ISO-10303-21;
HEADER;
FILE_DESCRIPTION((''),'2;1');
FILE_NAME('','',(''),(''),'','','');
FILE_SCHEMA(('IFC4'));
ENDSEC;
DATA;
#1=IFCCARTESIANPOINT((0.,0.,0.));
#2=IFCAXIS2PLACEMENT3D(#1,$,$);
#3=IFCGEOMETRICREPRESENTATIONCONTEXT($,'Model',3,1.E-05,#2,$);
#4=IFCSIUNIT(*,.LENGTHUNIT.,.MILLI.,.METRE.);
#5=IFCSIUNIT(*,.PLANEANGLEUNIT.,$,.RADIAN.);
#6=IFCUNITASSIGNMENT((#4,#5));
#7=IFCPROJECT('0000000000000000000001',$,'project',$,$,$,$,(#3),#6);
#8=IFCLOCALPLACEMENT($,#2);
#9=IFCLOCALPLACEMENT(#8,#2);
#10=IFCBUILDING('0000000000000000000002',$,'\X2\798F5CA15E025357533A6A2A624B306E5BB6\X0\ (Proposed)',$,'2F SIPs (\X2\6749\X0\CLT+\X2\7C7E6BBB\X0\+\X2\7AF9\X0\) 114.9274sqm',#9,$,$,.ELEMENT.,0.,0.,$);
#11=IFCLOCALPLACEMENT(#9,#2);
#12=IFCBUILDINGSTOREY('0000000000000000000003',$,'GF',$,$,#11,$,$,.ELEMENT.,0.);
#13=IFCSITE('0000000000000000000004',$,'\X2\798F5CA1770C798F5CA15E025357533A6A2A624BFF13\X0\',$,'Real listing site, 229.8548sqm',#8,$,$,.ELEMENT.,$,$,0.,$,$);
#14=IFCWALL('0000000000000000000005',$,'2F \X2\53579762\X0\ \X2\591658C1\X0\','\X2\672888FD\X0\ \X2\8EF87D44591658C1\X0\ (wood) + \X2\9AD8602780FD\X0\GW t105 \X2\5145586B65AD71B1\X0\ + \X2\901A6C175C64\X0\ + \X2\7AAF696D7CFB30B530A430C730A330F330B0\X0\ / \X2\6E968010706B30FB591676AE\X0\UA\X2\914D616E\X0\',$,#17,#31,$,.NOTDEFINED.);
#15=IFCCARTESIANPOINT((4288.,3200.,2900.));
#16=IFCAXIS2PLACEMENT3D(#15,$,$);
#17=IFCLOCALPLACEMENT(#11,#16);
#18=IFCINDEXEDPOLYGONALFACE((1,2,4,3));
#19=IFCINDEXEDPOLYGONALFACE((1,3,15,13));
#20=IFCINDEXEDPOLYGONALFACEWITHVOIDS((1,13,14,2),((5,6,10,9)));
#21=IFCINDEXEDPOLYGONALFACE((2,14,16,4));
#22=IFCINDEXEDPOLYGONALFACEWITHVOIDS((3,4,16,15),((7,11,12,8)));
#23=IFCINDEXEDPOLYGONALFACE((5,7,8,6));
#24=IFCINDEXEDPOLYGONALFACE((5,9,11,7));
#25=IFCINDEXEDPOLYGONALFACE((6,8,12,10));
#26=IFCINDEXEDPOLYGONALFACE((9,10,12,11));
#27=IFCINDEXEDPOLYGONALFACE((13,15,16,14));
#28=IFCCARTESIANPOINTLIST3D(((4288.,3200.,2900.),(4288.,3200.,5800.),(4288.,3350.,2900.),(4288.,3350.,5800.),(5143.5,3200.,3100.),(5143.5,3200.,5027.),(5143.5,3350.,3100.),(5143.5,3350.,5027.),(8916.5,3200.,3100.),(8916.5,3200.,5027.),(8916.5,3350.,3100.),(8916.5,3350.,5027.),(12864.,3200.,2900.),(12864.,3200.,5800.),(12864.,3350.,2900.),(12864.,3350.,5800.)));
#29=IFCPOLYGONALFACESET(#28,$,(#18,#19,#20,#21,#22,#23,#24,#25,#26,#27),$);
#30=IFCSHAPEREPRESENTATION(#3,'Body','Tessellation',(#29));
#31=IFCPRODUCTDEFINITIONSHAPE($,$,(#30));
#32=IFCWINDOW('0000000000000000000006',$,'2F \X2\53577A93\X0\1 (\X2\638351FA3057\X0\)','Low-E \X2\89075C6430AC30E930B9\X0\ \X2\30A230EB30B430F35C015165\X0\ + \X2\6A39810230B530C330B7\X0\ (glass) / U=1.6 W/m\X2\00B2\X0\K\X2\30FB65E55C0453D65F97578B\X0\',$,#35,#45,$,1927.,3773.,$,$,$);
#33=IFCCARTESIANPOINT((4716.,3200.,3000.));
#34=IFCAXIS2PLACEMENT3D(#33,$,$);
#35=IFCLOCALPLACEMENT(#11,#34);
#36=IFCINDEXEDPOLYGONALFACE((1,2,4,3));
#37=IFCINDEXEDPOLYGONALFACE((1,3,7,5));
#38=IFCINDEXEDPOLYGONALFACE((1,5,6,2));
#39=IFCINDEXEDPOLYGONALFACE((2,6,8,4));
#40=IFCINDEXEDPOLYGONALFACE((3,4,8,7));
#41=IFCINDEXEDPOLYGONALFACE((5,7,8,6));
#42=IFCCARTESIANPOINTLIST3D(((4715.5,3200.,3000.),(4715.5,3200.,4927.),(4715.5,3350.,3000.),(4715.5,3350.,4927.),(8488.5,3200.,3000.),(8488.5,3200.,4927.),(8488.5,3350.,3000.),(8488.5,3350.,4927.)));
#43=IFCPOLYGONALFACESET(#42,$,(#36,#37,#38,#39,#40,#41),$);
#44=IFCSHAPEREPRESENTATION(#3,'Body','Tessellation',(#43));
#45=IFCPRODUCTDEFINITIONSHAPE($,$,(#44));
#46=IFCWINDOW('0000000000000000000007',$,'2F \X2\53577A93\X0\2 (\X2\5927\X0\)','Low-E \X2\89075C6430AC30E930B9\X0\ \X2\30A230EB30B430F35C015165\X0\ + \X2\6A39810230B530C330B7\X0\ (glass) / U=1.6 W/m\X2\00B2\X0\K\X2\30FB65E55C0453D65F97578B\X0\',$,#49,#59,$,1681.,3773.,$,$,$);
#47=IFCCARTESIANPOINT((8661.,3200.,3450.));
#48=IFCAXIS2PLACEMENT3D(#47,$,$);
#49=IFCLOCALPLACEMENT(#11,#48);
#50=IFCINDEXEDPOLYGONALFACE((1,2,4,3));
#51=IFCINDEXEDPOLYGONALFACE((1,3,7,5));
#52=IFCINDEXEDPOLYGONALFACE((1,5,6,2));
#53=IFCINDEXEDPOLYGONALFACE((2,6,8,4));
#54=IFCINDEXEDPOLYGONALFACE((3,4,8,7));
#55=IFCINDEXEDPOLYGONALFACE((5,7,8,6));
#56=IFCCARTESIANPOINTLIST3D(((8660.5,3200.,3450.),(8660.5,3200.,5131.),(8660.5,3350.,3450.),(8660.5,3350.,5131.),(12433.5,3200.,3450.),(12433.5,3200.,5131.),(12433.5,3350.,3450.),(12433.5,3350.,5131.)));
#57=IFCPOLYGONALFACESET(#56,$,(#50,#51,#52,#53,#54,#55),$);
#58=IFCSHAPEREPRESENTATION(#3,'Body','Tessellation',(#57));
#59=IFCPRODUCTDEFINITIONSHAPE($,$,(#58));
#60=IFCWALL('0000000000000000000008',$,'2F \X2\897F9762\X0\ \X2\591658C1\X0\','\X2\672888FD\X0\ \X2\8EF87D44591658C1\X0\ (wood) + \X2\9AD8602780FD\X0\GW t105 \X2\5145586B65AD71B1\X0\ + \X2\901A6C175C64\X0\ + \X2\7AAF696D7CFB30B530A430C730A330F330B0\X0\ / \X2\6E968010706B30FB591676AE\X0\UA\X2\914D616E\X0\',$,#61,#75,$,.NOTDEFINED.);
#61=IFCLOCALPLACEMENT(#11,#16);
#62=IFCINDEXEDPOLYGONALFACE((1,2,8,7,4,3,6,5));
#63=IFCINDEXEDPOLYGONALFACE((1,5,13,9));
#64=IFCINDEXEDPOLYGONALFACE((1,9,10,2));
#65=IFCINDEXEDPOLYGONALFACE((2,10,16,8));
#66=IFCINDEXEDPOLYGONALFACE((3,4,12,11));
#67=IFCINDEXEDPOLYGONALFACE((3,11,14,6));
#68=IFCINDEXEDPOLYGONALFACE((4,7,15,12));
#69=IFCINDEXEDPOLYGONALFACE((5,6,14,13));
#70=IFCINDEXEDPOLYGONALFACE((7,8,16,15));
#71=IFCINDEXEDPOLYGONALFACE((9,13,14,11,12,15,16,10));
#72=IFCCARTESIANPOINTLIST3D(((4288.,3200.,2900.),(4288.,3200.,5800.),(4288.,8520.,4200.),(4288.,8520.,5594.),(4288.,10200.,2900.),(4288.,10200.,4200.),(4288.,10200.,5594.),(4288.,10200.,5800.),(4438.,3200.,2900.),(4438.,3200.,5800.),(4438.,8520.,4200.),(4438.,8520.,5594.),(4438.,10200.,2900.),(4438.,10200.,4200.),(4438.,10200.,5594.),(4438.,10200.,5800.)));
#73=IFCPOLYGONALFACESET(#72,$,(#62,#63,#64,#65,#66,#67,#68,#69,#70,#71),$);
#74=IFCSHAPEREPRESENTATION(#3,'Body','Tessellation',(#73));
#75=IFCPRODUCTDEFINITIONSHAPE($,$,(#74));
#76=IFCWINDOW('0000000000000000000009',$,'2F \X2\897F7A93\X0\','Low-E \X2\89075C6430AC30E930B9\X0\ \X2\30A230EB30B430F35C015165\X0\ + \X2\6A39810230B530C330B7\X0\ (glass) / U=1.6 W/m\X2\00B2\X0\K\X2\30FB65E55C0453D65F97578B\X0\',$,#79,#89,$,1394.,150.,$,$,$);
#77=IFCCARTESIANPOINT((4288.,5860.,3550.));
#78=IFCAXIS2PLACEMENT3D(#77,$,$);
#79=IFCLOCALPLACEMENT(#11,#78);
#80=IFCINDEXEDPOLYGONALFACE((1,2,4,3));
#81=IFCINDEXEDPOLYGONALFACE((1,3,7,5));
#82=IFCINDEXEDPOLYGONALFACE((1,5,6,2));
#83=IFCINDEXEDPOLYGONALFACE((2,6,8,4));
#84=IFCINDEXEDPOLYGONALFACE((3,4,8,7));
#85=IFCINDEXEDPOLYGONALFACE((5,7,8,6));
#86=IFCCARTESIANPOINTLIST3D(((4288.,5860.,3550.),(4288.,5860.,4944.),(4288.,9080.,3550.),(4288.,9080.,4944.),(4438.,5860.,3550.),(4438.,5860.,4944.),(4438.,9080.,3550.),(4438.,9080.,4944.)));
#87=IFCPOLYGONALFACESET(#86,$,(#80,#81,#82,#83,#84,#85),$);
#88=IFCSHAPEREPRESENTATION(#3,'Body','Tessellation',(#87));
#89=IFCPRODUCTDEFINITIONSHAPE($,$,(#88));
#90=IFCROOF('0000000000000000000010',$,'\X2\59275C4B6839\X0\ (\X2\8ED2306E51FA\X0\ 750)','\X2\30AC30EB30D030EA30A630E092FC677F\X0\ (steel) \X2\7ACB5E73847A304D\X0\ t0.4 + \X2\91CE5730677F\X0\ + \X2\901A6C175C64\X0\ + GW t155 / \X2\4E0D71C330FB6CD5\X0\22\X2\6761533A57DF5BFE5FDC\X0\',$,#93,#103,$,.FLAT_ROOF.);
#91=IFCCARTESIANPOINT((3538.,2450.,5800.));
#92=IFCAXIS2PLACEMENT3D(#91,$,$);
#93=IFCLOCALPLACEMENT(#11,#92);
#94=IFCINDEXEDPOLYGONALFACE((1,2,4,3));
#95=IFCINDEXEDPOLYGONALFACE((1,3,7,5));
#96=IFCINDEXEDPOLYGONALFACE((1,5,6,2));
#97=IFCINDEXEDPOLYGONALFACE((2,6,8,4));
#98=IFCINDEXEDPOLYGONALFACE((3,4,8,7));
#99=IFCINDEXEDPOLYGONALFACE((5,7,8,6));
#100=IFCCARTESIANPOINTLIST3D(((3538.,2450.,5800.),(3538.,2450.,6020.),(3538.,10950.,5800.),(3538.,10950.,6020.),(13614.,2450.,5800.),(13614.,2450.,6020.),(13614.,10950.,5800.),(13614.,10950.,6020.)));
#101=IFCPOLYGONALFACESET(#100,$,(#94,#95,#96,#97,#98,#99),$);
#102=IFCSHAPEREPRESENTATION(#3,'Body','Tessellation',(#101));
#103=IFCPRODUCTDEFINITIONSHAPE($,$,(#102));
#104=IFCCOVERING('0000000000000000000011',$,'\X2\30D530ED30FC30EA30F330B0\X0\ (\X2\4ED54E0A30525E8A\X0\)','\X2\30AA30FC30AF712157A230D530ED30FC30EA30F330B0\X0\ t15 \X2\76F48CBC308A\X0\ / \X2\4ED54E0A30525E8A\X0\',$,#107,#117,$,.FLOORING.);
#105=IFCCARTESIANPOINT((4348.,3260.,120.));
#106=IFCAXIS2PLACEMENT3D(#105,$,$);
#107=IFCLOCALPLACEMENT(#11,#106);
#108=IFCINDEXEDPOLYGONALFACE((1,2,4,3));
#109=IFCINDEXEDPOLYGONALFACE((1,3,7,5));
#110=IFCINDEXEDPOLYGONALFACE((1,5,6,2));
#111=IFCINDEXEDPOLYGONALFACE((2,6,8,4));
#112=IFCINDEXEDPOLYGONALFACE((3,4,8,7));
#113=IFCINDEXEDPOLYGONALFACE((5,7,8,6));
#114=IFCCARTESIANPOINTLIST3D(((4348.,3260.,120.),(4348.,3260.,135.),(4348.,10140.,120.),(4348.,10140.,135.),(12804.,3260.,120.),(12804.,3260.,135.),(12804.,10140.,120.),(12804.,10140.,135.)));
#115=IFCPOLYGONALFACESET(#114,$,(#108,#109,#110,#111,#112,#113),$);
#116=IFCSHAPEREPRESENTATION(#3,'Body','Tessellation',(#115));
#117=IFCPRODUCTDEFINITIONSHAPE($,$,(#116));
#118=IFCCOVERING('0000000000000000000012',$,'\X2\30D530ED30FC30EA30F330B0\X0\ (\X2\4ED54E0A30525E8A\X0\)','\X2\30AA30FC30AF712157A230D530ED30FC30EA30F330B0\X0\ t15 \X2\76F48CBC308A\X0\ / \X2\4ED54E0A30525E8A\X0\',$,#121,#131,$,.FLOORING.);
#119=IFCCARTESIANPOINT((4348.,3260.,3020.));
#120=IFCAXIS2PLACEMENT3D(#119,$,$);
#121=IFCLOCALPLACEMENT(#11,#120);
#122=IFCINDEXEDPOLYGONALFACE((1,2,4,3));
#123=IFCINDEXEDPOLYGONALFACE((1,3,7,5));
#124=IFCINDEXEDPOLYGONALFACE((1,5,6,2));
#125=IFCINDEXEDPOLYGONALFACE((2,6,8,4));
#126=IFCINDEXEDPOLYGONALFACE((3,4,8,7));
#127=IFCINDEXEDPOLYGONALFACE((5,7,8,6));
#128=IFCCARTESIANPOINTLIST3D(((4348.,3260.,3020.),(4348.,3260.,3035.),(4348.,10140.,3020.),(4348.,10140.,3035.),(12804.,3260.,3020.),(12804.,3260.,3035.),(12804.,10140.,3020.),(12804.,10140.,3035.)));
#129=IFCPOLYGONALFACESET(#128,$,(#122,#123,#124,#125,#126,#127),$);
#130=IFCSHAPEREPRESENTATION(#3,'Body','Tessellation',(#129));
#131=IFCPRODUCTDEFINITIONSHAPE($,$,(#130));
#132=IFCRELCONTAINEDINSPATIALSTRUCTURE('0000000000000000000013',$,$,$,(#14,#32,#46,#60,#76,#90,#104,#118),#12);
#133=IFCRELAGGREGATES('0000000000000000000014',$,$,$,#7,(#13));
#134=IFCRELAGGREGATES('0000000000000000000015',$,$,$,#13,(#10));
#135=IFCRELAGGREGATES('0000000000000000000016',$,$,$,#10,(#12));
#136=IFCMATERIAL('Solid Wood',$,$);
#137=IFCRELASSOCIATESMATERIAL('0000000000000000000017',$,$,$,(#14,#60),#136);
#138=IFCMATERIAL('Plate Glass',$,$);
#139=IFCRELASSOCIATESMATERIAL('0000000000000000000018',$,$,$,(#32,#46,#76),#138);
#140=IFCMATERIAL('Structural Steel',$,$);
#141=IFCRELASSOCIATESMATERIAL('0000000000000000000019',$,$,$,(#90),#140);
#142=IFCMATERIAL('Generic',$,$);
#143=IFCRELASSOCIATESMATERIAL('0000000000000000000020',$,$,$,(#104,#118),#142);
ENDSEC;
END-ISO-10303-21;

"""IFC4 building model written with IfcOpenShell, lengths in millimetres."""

from ifc_helpers import new_model, si_unit, frame, frame_2d, origin, place, context, project, spatial, rectangle, extrude, material, element, fill, save


model = new_model("IFC4")

# Units and contexts
model_context = context("Model", 3, precision=1e-05, world=origin())
ifc_project = project(units=[si_unit("LENGTHUNIT", "METRE", prefix="MILLI"), si_unit("PLANEANGLEUNIT", "RADIAN")], contexts=[model_context])

# Site, building, storey
site_placement = place(None, origin())
site = spatial("IfcSite", under=ifc_project, at=site_placement, Name="福岡県福岡市南区横手３", ObjectType="Real listing site, 229.8548sqm", CompositionType="ELEMENT", RefElevation=0.0)
building_placement = place(site_placement, origin())
building = spatial("IfcBuilding", under=site, at=building_placement, Name="福岡市南区横手の家 (Proposed)", ObjectType="2F SIPs (杉CLT+籾殻+竹) 114.9274sqm", CompositionType="ELEMENT", ElevationOfRefHeight=0.0, ElevationOfTerrain=0.0)
storey_placement = place(building_placement, origin())
storey = spatial("IfcBuildingStorey", under=building, at=storey_placement, Name="GF", CompositionType="ELEMENT", Elevation=0.0)

# Shared definitions
ifc_material_1 = material(Name="Solid Wood")

# Shared definitions
ifc_material_2 = material(Name="Plate Glass")

# Wall, openings, windows
wall_1_placement = place(storey_placement, frame((4288.0, 3200.0, 2900.0)))
wall_1 = element("IfcWall", 1, at=wall_1_placement, inside=storey, material=ifc_material_1, Name="2F 南面 外壁", Description="木製 軸組外壁 (wood) + 高性能GW t105 充填断熱 + 通気層 + 窯業系サイディング / 準耐火・外皮UA配慮", PredefinedType="NOTDEFINED", context=model_context, shape_type="SweptSolid", body=[
    extrude(rectangle(XDim=8576.0, YDim=150.0, at=frame_2d((4288.0, 75.0))), frame((4288.0, 3200.0, 2900.0)), (0.0, 0.0, 1.0), 2900.0),
])
opening_1_placement = place(storey_placement, frame((4716.0, 3200.0, 3000.0)))
opening_1 = element("IfcOpeningElement", 2, at=opening_1_placement, cuts=wall_1, PredefinedType="NOTDEFINED", context=model_context, shape_type="SweptSolid", body=[
    extrude(rectangle(XDim=3773.0, YDim=150.0, at=frame_2d((1886.0, 75.0))), frame((4716.0, 3200.0, 3000.0)), (0.0, 0.0, 1.0), 1927.0),
])
opening_2_placement = place(storey_placement, frame((8661.0, 3200.0, 3450.0)))
opening_2 = element("IfcOpeningElement", 3, at=opening_2_placement, cuts=wall_1, PredefinedType="NOTDEFINED", context=model_context, shape_type="SweptSolid", body=[
    extrude(rectangle(XDim=3773.0, YDim=150.0, at=frame_2d((1886.0, 75.0))), frame((8661.0, 3200.0, 3450.0)), (0.0, 0.0, 1.0), 1681.0),
])
window_1_placement = place(storey_placement, frame((4716.0, 3200.0, 3000.0)))
window_1 = element("IfcWindow", 4, at=window_1_placement, inside=storey, material=ifc_material_2, Name="2F 南窓1 (掃出し)", Description="Low-E 複層ガラス アルゴン封入 + 樹脂サッシ (glass) / U=1.6 W/m²K・日射取得型", OverallHeight=1927.0, OverallWidth=3773.0, context=model_context, shape_type="SweptSolid", body=[
    extrude(rectangle(XDim=3773.0, YDim=150.0, at=frame_2d((1886.0, 75.0))), frame((4716.0, 3200.0, 3000.0)), (0.0, 0.0, 1.0), 1927.0),
])
fill(opening_1, window_1)
window_2_placement = place(storey_placement, frame((8661.0, 3200.0, 3450.0)))
window_2 = element("IfcWindow", 5, at=window_2_placement, inside=storey, material=ifc_material_2, Name="2F 南窓2 (大)", Description="Low-E 複層ガラス アルゴン封入 + 樹脂サッシ (glass) / U=1.6 W/m²K・日射取得型", OverallHeight=1681.0, OverallWidth=3773.0, context=model_context, shape_type="SweptSolid", body=[
    extrude(rectangle(XDim=3773.0, YDim=150.0, at=frame_2d((1886.0, 75.0))), frame((8661.0, 3200.0, 3450.0)), (0.0, 0.0, 1.0), 1681.0),
])
fill(opening_2, window_2)

# Wall, opening, window
wall_2_placement = place(storey_placement, frame((4288.0, 3200.0, 2900.0)))
wall_2 = element("IfcWall", 6, at=wall_2_placement, inside=storey, material=ifc_material_1, Name="2F 西面 外壁", Description="木製 軸組外壁 (wood) + 高性能GW t105 充填断熱 + 通気層 + 窯業系サイディング / 準耐火・外皮UA配慮", PredefinedType="NOTDEFINED", context=model_context, shape_type="SweptSolid", body=[
    extrude(rectangle(XDim=150.0, YDim=7000.0, at=frame_2d((75.0, 3500.0))), frame((4288.0, 3200.0, 2900.0)), (0.0, 0.0, 1.0), 2900.0),
])
opening_3_placement = place(storey_placement, frame((4288.0, 5860.0, 3550.0)))
opening_3 = element("IfcOpeningElement", 7, at=opening_3_placement, cuts=wall_2, PredefinedType="NOTDEFINED", context=model_context, shape_type="SweptSolid", body=[
    extrude(rectangle(XDim=150.0, YDim=3220.0, at=frame_2d((75.0, 1610.0))), frame((4288.0, 5860.0, 3550.0)), (0.0, 0.0, 1.0), 1394.0),
])
window_3_placement = place(storey_placement, frame((4288.0, 5860.0, 3550.0)))
window_3 = element("IfcWindow", 8, at=window_3_placement, inside=storey, material=ifc_material_2, Name="2F 西窓", Description="Low-E 複層ガラス アルゴン封入 + 樹脂サッシ (glass) / U=1.6 W/m²K・日射取得型", OverallHeight=1394.0, OverallWidth=150.0, context=model_context, shape_type="SweptSolid", body=[
    extrude(rectangle(XDim=150.0, YDim=3220.0, at=frame_2d((75.0, 1610.0))), frame((4288.0, 5860.0, 3550.0)), (0.0, 0.0, 1.0), 1394.0),
])
fill(opening_3, window_3)

# Roof
ifc_material_3 = material(Name="Structural Steel")
roof_placement = place(storey_placement, frame((3538.0, 2450.0, 5800.0)))
element("IfcRoof", 9, at=roof_placement, inside=storey, material=ifc_material_3, Name="大屋根 (軒の出 750)", Description="ガルバリウム鋼板 (steel) 立平葺き t0.4 + 野地板 + 通気層 + GW t155 / 不燃・法22条区域対応", PredefinedType="FLAT_ROOF", context=model_context, shape_type="SweptSolid", body=[
    extrude(rectangle(XDim=10076.0, YDim=8500.0, at=frame_2d((5038.0, 4250.0))), frame((3538.0, 2450.0, 5800.0)), (0.0, 0.0, 1.0), 220.0),
])

# Coverings
ifc_material_4 = material(Name="Generic")
covering_1_placement = place(storey_placement, frame((4348.0, 3260.0, 120.0)))
element("IfcCovering", 10, at=covering_1_placement, inside=storey, material=ifc_material_4, Name="フローリング (仕上げ床)", Description="オーク無垢フローリング t15 直貼り / 仕上げ床", PredefinedType="FLOORING", context=model_context, shape_type="SweptSolid", body=[
    extrude(rectangle(XDim=8456.0, YDim=6880.0, at=frame_2d((4228.0, 3440.0))), frame((4348.0, 3260.0, 120.0)), (0.0, 0.0, 1.0), 15.0),
])
covering_2_placement = place(storey_placement, frame((4348.0, 3260.0, 3020.0)))
element("IfcCovering", 11, at=covering_2_placement, inside=storey, material=ifc_material_4, Name="フローリング (仕上げ床)", Description="オーク無垢フローリング t15 直貼り / 仕上げ床", PredefinedType="FLOORING", context=model_context, shape_type="SweptSolid", body=[
    extrude(rectangle(XDim=8456.0, YDim=6880.0, at=frame_2d((4228.0, 3440.0))), frame((4348.0, 3260.0, 3020.0)), (0.0, 0.0, 1.0), 15.0),
])

save(model, "model.ifc")
